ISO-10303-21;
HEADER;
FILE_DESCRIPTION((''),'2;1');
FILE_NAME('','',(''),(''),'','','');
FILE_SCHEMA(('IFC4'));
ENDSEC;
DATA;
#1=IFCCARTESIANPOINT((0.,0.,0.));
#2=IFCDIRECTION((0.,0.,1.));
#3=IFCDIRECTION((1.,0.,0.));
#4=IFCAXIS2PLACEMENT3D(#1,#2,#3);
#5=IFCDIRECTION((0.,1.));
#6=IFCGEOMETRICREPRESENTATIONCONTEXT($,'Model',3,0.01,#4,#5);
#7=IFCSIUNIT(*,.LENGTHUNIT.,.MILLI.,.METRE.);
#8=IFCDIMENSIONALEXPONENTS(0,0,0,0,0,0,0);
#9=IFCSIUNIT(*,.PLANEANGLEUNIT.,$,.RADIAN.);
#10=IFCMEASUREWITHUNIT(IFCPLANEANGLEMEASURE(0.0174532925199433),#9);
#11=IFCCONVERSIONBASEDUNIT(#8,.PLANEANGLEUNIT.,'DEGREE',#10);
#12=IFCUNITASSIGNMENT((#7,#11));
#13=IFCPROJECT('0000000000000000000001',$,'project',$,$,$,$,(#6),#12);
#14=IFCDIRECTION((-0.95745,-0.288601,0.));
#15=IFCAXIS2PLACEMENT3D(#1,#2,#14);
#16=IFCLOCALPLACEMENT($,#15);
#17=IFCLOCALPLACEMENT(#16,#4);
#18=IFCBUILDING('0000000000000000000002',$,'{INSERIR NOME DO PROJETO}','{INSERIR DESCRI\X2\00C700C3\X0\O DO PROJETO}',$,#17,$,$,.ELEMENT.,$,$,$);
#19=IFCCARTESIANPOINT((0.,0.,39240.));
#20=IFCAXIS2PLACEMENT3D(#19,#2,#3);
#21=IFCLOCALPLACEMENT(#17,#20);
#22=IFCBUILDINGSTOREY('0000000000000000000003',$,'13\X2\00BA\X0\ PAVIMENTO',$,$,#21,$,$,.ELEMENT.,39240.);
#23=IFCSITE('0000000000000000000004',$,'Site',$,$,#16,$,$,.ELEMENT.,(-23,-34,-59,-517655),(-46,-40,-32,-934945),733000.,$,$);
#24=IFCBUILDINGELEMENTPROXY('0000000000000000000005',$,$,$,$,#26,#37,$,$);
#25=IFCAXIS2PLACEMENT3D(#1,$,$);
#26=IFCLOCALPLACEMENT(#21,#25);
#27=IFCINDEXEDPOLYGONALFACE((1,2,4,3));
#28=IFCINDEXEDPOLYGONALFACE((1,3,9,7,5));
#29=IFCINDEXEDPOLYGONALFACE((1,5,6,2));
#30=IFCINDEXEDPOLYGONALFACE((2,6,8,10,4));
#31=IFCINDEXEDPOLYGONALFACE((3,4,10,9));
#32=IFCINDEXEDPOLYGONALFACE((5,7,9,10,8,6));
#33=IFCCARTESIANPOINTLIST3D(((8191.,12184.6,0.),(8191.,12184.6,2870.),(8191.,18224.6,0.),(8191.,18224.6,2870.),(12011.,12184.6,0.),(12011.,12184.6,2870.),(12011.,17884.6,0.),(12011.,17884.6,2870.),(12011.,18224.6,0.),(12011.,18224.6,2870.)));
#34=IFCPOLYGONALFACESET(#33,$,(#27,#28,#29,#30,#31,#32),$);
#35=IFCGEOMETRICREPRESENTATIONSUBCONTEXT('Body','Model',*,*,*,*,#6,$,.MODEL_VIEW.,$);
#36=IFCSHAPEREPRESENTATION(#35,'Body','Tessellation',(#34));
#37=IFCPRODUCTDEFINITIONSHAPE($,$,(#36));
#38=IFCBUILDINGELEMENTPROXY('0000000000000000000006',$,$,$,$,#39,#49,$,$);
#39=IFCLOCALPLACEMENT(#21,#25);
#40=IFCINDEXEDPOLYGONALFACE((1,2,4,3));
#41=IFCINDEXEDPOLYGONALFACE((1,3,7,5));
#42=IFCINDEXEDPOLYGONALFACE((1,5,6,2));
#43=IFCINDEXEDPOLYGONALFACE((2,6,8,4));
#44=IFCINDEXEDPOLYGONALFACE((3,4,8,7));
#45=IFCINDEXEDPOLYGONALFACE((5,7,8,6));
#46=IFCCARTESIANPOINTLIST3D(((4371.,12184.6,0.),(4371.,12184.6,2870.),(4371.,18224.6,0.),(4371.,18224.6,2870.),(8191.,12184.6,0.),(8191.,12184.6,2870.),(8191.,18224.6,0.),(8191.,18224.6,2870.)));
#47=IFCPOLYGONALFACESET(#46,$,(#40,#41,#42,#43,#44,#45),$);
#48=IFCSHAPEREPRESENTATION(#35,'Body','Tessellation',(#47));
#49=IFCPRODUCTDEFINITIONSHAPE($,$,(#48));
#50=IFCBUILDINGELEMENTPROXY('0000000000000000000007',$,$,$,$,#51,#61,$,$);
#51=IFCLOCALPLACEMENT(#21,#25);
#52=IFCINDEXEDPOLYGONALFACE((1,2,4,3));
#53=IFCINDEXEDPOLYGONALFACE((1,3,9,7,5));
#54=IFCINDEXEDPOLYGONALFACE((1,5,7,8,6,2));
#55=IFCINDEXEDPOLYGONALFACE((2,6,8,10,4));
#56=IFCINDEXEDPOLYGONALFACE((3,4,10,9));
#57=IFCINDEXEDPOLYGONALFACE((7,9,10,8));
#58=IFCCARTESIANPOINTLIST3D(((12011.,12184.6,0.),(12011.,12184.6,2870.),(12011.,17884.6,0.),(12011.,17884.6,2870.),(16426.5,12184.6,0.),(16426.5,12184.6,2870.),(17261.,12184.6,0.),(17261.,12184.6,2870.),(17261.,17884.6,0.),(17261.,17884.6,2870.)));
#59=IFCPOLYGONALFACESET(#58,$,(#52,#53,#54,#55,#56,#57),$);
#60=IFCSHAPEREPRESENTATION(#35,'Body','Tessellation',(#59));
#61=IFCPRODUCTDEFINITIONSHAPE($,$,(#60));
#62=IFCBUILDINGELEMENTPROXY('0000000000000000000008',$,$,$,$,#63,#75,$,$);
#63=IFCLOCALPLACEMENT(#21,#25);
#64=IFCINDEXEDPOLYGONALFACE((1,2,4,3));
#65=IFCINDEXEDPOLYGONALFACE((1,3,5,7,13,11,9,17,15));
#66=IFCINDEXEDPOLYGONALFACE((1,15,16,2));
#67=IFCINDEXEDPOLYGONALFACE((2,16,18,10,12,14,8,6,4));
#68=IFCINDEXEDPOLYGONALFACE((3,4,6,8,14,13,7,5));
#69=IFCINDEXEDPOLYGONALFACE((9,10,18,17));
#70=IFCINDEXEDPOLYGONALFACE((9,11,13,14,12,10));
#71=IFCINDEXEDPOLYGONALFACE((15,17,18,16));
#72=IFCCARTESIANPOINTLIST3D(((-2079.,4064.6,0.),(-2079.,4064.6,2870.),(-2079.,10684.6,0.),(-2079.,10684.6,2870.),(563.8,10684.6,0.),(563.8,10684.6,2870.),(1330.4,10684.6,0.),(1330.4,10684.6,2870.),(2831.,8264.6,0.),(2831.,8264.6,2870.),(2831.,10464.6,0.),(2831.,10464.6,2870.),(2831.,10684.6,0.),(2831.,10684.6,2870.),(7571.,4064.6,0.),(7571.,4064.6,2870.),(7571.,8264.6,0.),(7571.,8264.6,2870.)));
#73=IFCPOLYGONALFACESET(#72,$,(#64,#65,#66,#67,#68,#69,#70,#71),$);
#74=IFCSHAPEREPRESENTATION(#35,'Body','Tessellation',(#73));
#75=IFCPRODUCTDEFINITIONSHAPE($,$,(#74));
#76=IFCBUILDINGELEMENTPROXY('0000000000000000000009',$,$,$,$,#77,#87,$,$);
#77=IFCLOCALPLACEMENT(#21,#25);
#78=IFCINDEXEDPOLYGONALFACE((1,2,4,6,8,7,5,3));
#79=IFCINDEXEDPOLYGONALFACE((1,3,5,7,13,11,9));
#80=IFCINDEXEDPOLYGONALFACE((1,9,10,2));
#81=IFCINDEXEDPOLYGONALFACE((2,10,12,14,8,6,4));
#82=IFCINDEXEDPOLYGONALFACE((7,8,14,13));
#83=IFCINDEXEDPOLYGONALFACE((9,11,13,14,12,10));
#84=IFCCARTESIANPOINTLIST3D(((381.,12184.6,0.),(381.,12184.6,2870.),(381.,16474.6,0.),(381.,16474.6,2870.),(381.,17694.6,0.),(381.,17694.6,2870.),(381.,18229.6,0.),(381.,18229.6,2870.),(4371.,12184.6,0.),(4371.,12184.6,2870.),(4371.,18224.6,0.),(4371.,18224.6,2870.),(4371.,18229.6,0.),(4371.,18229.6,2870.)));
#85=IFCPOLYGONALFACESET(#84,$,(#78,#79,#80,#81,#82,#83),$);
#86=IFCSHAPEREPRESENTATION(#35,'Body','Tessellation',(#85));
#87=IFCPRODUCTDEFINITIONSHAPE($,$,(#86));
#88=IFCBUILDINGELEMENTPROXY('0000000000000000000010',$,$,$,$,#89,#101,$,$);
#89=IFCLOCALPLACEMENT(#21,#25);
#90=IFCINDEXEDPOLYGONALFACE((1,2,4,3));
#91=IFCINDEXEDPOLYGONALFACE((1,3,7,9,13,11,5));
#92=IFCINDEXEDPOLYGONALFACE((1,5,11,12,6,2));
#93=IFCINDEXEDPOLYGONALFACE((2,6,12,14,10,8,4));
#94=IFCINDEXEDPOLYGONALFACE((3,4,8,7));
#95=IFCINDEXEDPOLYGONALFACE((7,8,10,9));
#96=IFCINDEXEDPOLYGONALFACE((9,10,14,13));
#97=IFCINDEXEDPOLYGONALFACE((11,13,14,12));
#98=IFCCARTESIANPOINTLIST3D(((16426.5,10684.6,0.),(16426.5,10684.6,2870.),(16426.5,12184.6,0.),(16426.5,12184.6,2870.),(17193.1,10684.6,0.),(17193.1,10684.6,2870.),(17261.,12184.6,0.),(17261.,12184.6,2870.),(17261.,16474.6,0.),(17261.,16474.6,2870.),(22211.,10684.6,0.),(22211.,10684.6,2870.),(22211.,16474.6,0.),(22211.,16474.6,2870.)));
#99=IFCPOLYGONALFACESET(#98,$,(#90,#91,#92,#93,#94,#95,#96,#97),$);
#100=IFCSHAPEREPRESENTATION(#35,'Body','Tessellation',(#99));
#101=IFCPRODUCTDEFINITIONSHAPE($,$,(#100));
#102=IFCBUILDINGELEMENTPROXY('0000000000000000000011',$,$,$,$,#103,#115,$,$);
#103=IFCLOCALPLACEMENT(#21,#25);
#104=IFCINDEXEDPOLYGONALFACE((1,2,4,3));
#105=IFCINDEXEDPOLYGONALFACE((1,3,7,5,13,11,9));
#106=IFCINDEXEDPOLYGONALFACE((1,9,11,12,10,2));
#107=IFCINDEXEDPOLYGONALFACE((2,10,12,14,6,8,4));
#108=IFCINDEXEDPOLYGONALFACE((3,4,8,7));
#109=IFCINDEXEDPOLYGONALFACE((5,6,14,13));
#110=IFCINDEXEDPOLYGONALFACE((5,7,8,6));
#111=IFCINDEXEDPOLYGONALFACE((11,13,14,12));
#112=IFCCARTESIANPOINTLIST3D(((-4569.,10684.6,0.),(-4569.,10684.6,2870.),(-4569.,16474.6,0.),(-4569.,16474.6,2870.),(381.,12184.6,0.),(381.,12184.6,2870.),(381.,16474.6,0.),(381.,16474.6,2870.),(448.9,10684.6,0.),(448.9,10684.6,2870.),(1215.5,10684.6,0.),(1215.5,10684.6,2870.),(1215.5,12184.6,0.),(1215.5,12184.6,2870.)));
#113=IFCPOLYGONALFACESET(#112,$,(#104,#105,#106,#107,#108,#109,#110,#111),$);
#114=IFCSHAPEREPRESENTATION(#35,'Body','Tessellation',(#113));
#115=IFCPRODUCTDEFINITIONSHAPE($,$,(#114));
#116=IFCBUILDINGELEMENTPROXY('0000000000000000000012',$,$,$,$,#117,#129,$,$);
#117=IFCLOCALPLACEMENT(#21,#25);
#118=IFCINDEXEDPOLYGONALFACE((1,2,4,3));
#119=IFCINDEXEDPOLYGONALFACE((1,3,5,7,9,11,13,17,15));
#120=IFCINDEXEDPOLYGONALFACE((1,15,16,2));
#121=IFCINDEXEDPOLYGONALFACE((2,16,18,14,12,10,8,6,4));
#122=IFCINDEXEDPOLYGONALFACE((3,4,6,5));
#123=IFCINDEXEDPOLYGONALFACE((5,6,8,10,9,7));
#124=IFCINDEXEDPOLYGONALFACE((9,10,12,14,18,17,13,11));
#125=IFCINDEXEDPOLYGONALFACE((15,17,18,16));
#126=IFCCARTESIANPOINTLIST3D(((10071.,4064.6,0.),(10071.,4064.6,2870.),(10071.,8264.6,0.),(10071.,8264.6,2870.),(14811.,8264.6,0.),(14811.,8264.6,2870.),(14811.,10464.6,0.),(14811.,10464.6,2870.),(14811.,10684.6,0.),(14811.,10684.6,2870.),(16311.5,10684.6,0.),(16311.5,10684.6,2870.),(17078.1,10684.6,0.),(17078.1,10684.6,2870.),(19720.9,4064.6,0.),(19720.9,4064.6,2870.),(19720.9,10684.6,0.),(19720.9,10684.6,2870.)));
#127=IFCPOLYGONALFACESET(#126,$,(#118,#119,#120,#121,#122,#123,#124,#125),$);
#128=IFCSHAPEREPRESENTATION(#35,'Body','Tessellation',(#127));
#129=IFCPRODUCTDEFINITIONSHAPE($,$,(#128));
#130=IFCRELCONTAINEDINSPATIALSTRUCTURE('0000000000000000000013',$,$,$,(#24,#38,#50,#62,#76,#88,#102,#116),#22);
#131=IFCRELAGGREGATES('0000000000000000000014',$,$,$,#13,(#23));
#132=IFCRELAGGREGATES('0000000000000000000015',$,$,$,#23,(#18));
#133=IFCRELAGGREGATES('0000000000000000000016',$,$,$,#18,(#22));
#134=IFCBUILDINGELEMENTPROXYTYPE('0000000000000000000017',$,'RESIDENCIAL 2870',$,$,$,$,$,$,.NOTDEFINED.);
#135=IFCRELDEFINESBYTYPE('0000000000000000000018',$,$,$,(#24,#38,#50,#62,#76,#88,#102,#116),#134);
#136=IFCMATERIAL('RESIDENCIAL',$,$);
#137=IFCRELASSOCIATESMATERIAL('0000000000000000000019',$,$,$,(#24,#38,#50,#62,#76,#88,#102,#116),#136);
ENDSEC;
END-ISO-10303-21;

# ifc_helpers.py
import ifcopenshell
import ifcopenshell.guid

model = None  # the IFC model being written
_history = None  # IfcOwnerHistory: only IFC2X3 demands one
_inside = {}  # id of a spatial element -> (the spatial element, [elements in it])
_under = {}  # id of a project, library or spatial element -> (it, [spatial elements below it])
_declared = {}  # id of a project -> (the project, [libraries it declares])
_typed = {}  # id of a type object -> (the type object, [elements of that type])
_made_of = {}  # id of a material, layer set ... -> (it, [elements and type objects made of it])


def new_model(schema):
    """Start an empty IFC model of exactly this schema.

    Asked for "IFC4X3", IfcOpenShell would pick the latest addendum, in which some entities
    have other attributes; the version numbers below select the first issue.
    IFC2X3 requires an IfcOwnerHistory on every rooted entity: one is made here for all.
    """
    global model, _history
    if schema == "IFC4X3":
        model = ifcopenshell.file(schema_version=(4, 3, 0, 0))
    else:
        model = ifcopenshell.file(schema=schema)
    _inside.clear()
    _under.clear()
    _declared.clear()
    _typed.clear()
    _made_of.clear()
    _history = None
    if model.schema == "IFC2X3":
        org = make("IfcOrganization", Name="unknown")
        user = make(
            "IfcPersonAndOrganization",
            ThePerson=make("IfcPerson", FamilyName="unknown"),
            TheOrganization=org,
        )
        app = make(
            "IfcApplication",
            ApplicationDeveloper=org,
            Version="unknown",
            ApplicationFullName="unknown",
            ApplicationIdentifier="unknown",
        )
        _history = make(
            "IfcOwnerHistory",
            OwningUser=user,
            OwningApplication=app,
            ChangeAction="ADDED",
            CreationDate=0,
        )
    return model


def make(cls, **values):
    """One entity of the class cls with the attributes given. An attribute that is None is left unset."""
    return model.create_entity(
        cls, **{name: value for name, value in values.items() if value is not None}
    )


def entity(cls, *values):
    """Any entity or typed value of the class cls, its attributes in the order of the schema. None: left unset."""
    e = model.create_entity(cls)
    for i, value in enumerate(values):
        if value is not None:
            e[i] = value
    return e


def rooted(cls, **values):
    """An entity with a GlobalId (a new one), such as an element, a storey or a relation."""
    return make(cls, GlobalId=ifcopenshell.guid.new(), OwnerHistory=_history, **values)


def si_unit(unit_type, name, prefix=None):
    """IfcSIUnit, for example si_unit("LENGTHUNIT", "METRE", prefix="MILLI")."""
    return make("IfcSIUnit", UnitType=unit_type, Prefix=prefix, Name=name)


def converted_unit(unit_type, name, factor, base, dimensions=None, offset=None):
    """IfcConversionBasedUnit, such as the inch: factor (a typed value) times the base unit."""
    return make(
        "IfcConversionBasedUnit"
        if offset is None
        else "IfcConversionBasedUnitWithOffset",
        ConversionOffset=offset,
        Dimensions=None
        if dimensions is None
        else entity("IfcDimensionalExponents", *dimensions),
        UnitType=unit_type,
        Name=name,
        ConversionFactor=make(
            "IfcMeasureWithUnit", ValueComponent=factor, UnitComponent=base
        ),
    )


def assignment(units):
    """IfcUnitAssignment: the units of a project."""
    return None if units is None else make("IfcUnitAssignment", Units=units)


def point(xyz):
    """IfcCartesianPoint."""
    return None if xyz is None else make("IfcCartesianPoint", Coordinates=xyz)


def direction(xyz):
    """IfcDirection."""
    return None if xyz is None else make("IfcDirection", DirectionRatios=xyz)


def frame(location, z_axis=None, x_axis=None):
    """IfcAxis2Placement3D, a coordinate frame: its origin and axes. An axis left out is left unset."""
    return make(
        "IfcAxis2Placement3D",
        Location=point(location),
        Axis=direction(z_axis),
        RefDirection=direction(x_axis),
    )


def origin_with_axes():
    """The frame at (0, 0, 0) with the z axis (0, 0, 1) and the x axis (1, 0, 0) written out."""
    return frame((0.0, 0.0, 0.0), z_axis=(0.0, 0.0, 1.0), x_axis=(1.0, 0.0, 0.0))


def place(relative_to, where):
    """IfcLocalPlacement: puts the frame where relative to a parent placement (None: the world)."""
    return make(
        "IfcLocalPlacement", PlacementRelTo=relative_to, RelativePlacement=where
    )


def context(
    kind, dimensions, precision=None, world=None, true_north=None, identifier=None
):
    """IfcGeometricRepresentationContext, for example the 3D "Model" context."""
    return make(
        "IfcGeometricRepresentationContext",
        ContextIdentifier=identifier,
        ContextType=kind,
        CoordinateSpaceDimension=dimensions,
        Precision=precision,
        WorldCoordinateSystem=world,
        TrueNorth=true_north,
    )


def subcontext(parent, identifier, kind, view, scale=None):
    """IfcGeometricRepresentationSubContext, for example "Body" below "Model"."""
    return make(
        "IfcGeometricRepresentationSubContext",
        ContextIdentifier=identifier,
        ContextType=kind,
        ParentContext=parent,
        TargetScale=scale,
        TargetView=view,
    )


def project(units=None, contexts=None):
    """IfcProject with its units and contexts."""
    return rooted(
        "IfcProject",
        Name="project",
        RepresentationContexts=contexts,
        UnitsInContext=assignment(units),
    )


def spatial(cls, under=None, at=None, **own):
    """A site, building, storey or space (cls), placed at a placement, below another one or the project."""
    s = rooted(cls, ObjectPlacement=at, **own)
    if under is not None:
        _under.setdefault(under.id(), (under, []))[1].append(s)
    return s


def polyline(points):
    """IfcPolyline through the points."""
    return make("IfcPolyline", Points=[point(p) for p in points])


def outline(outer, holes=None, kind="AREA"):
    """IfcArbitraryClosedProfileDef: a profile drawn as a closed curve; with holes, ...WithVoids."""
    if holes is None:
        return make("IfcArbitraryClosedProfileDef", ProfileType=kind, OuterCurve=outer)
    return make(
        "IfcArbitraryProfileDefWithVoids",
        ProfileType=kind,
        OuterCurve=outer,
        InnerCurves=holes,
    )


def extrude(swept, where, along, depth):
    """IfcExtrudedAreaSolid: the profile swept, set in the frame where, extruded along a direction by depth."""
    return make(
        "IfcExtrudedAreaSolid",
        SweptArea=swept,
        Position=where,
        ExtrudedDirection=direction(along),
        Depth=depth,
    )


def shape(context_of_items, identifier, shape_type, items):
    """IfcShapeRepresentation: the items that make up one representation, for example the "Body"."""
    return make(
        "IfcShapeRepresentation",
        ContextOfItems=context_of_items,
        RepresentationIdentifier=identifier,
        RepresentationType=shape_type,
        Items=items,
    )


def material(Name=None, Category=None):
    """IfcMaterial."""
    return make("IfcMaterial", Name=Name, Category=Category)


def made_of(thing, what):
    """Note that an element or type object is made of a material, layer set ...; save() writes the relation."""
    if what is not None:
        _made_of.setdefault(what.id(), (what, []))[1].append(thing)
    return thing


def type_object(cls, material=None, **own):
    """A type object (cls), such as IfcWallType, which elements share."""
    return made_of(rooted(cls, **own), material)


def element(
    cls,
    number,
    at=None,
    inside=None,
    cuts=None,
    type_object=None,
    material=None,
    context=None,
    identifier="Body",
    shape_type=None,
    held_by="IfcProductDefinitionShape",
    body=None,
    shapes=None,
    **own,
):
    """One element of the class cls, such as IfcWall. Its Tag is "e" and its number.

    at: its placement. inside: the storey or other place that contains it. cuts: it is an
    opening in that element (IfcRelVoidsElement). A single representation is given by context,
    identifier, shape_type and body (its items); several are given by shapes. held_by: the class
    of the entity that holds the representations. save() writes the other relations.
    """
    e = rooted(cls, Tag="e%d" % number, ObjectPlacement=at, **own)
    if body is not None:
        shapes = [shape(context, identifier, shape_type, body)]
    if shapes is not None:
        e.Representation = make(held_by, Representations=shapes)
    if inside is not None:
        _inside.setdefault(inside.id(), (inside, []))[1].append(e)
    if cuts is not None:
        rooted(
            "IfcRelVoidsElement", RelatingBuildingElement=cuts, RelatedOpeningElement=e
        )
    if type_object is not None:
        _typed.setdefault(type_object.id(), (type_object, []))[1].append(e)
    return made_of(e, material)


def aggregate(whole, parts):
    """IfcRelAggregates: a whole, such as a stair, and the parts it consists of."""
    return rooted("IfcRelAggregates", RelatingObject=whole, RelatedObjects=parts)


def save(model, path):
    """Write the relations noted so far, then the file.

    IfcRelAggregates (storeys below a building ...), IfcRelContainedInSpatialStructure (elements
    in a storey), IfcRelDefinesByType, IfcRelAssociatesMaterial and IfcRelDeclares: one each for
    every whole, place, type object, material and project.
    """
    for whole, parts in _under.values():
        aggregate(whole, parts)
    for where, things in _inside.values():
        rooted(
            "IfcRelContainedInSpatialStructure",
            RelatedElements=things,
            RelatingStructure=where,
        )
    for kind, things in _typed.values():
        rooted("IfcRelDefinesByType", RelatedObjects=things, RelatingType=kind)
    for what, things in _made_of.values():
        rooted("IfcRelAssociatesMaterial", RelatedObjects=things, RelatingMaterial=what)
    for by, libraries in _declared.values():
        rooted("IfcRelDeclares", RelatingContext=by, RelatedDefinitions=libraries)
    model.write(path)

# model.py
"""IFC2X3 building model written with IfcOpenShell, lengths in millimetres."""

from ifc_helpers import new_model, entity, si_unit, converted_unit, direction, frame, origin_with_axes, place, context, subcontext, project, spatial, polyline, outline, extrude, material, type_object, element, save


model = new_model("IFC2X3")

# Units and contexts
model_context = context("Model", 3, precision=0.01, world=origin_with_axes(), true_north=direction((0.0, 1.0)))
body_context = subcontext(model_context, "Body", "Model", "MODEL_VIEW")
ifc_project = project(units=[si_unit("LENGTHUNIT", "METRE", prefix="MILLI"), converted_unit("PLANEANGLEUNIT", "DEGREE", entity("IfcPlaneAngleMeasure", 0.0174532925199433), si_unit("PLANEANGLEUNIT", "RADIAN"), dimensions=[0, 0, 0, 0, 0, 0, 0])], contexts=[model_context])

# Site, building, storey
site_placement = place(None, frame((0.0, 0.0, 0.0), z_axis=(0.0, 0.0, 1.0), x_axis=(-0.95745, -0.288601, 0.0)))
site = spatial("IfcSite", under=ifc_project, at=site_placement, Name="Site", CompositionType="ELEMENT", RefLatitude=(-23, -34, -59, -517655), RefLongitude=(-46, -40, -32, -934945), RefElevation=733000.0)
building_placement = place(site_placement, origin_with_axes())
building = spatial("IfcBuilding", under=site, at=building_placement, Name="{INSERIR NOME DO PROJETO}", Description="{INSERIR DESCRIÇÃO DO PROJETO}", CompositionType="ELEMENT")
storey_placement = place(building_placement, frame((0.0, 0.0, 39240.0), z_axis=(0.0, 0.0, 1.0), x_axis=(1.0, 0.0, 0.0)))
storey = spatial("IfcBuildingStorey", under=building, at=storey_placement, Name="13º PAVIMENTO", CompositionType="ELEMENT", Elevation=39240.0)

# Building element proxies
ifc_material_1 = material(Name="RESIDENCIAL")
building_element_proxy_type_1 = type_object("IfcBuildingElementProxyType", Name="RESIDENCIAL 2870", PredefinedType="NOTDEFINED")
proxy_1_placement = place(storey_placement, frame((8191.0, 18224.6, 0.0), z_axis=(0.0, 0.0, 1.0), x_axis=(1.0, 0.0, 0.0)))
element("IfcBuildingElementProxy", 1, at=proxy_1_placement, inside=storey, type_object=building_element_proxy_type_1, material=ifc_material_1, context=body_context, shape_type="SweptSolid", body=[
    extrude(outline(polyline([(0.0, 0.0), (0.0, -6040.0), (3820.0, -6040.0), (3820.0, -340.0), (3820.0, 0.0), (0.0, 0.0)])), origin_with_axes(), (0.0, 0.0, 1.0), 2870.0),
])
proxy_2_placement = place(storey_placement, frame((4371.0, 18224.6, 0.0), z_axis=(0.0, 0.0, 1.0), x_axis=(1.0, 0.0, 0.0)))
element("IfcBuildingElementProxy", 2, at=proxy_2_placement, inside=storey, type_object=building_element_proxy_type_1, material=ifc_material_1, context=body_context, shape_type="SweptSolid", body=[
    extrude(outline(polyline([(0.0, 0.0), (0.0, -6040.0), (3820.0, -6040.0), (3820.0, 0.0), (0.0, 0.0)])), origin_with_axes(), (0.0, 0.0, 1.0), 2870.0),
])
proxy_3_placement = place(storey_placement, frame((12011.0, 12184.6, 0.0), z_axis=(0.0, 0.0, 1.0), x_axis=(1.0, 0.0, 0.0)))
element("IfcBuildingElementProxy", 3, at=proxy_3_placement, inside=storey, type_object=building_element_proxy_type_1, material=ifc_material_1, context=body_context, shape_type="SweptSolid", body=[
    extrude(outline(polyline([(0.0, 0.0), (4415.5, 0.0), (5250.0, 0.0), (5250.0, 5700.0), (0.0, 5700.0), (0.0, 0.0)])), origin_with_axes(), (0.0, 0.0, 1.0), 2870.0),
])
proxy_4_placement = place(storey_placement, frame((-2079.0, 4064.6, 0.0), z_axis=(0.0, 0.0, 1.0), x_axis=(1.0, 0.0, 0.0)))
element("IfcBuildingElementProxy", 4, at=proxy_4_placement, inside=storey, type_object=building_element_proxy_type_1, material=ifc_material_1, context=body_context, shape_type="SweptSolid", body=[
    extrude(outline(polyline([(0.0, 0.0), (9650.0, 0.0), (9650.0, 4200.0), (4910.0, 4200.0), (4910.0, 6400.0), (4910.0, 6620.0), (3409.4, 6620.0), (2642.8, 6620.0), (0.0, 6620.0), (0.0, 0.0)])), origin_with_axes(), (0.0, 0.0, 1.0), 2870.0),
])
proxy_5_placement = place(storey_placement, frame((381.0, 16474.6, 0.0), z_axis=(0.0, 0.0, 1.0), x_axis=(1.0, 0.0, 0.0)))
element("IfcBuildingElementProxy", 5, at=proxy_5_placement, inside=storey, type_object=building_element_proxy_type_1, material=ifc_material_1, context=body_context, shape_type="SweptSolid", body=[
    extrude(outline(polyline([(0.0, 0.0), (0.0, -4290.0), (3990.0, -4290.0), (3990.0, 1750.0), (3990.0, 1755.0), (0.0, 1755.0), (0.0, 1220.0), (0.0, 0.0)])), origin_with_axes(), (0.0, 0.0, 1.0), 2870.0),
])
proxy_6_placement = place(storey_placement, frame((17261.0, 12184.6, 0.0), z_axis=(0.0, 0.0, 1.0), x_axis=(1.0, 0.0, 0.0)))
element("IfcBuildingElementProxy", 6, at=proxy_6_placement, inside=storey, type_object=building_element_proxy_type_1, material=ifc_material_1, context=body_context, shape_type="SweptSolid", body=[
    extrude(outline(polyline([(0.0, 0.0), (-834.5, 0.0), (-834.5, -1500.0), (-67.9, -1500.0), (4950.0, -1500.0), (4950.0, 4290.0), (0.0, 4290.0), (0.0, 0.0)])), origin_with_axes(), (0.0, 0.0, 1.0), 2870.0),
])
proxy_7_placement = place(storey_placement, frame((-4569.0, 16474.6, 0.0), z_axis=(0.0, 0.0, 1.0), x_axis=(1.0, 0.0, 0.0)))
element("IfcBuildingElementProxy", 7, at=proxy_7_placement, inside=storey, type_object=building_element_proxy_type_1, material=ifc_material_1, context=body_context, shape_type="SweptSolid", body=[
    extrude(outline(polyline([(0.0, 0.0), (0.0, -5790.0), (5017.9, -5790.0), (5784.5, -5790.0), (5784.5, -4290.0), (4950.0, -4290.0), (4950.0, 0.0), (0.0, 0.0)])), origin_with_axes(), (0.0, 0.0, 1.0), 2870.0),
])
proxy_8_placement = place(storey_placement, frame((19720.9, 4064.6, 0.0), z_axis=(0.0, 0.0, 1.0), x_axis=(1.0, 0.0, 0.0)))
element("IfcBuildingElementProxy", 8, at=proxy_8_placement, inside=storey, type_object=building_element_proxy_type_1, material=ifc_material_1, context=body_context, shape_type="SweptSolid", body=[
    extrude(outline(polyline([(0.0, 0.0), (0.0, 6620.0), (-2642.8, 6620.0), (-3409.4, 6620.0), (-4910.0, 6620.0), (-4910.0, 6400.0), (-4910.0, 4200.0), (-9650.0, 4200.0), (-9650.0, 0.0), (0.0, 0.0)])), origin_with_axes(), (0.0, 0.0, 1.0), 2870.0),
])

save(model, "model.ifc")
